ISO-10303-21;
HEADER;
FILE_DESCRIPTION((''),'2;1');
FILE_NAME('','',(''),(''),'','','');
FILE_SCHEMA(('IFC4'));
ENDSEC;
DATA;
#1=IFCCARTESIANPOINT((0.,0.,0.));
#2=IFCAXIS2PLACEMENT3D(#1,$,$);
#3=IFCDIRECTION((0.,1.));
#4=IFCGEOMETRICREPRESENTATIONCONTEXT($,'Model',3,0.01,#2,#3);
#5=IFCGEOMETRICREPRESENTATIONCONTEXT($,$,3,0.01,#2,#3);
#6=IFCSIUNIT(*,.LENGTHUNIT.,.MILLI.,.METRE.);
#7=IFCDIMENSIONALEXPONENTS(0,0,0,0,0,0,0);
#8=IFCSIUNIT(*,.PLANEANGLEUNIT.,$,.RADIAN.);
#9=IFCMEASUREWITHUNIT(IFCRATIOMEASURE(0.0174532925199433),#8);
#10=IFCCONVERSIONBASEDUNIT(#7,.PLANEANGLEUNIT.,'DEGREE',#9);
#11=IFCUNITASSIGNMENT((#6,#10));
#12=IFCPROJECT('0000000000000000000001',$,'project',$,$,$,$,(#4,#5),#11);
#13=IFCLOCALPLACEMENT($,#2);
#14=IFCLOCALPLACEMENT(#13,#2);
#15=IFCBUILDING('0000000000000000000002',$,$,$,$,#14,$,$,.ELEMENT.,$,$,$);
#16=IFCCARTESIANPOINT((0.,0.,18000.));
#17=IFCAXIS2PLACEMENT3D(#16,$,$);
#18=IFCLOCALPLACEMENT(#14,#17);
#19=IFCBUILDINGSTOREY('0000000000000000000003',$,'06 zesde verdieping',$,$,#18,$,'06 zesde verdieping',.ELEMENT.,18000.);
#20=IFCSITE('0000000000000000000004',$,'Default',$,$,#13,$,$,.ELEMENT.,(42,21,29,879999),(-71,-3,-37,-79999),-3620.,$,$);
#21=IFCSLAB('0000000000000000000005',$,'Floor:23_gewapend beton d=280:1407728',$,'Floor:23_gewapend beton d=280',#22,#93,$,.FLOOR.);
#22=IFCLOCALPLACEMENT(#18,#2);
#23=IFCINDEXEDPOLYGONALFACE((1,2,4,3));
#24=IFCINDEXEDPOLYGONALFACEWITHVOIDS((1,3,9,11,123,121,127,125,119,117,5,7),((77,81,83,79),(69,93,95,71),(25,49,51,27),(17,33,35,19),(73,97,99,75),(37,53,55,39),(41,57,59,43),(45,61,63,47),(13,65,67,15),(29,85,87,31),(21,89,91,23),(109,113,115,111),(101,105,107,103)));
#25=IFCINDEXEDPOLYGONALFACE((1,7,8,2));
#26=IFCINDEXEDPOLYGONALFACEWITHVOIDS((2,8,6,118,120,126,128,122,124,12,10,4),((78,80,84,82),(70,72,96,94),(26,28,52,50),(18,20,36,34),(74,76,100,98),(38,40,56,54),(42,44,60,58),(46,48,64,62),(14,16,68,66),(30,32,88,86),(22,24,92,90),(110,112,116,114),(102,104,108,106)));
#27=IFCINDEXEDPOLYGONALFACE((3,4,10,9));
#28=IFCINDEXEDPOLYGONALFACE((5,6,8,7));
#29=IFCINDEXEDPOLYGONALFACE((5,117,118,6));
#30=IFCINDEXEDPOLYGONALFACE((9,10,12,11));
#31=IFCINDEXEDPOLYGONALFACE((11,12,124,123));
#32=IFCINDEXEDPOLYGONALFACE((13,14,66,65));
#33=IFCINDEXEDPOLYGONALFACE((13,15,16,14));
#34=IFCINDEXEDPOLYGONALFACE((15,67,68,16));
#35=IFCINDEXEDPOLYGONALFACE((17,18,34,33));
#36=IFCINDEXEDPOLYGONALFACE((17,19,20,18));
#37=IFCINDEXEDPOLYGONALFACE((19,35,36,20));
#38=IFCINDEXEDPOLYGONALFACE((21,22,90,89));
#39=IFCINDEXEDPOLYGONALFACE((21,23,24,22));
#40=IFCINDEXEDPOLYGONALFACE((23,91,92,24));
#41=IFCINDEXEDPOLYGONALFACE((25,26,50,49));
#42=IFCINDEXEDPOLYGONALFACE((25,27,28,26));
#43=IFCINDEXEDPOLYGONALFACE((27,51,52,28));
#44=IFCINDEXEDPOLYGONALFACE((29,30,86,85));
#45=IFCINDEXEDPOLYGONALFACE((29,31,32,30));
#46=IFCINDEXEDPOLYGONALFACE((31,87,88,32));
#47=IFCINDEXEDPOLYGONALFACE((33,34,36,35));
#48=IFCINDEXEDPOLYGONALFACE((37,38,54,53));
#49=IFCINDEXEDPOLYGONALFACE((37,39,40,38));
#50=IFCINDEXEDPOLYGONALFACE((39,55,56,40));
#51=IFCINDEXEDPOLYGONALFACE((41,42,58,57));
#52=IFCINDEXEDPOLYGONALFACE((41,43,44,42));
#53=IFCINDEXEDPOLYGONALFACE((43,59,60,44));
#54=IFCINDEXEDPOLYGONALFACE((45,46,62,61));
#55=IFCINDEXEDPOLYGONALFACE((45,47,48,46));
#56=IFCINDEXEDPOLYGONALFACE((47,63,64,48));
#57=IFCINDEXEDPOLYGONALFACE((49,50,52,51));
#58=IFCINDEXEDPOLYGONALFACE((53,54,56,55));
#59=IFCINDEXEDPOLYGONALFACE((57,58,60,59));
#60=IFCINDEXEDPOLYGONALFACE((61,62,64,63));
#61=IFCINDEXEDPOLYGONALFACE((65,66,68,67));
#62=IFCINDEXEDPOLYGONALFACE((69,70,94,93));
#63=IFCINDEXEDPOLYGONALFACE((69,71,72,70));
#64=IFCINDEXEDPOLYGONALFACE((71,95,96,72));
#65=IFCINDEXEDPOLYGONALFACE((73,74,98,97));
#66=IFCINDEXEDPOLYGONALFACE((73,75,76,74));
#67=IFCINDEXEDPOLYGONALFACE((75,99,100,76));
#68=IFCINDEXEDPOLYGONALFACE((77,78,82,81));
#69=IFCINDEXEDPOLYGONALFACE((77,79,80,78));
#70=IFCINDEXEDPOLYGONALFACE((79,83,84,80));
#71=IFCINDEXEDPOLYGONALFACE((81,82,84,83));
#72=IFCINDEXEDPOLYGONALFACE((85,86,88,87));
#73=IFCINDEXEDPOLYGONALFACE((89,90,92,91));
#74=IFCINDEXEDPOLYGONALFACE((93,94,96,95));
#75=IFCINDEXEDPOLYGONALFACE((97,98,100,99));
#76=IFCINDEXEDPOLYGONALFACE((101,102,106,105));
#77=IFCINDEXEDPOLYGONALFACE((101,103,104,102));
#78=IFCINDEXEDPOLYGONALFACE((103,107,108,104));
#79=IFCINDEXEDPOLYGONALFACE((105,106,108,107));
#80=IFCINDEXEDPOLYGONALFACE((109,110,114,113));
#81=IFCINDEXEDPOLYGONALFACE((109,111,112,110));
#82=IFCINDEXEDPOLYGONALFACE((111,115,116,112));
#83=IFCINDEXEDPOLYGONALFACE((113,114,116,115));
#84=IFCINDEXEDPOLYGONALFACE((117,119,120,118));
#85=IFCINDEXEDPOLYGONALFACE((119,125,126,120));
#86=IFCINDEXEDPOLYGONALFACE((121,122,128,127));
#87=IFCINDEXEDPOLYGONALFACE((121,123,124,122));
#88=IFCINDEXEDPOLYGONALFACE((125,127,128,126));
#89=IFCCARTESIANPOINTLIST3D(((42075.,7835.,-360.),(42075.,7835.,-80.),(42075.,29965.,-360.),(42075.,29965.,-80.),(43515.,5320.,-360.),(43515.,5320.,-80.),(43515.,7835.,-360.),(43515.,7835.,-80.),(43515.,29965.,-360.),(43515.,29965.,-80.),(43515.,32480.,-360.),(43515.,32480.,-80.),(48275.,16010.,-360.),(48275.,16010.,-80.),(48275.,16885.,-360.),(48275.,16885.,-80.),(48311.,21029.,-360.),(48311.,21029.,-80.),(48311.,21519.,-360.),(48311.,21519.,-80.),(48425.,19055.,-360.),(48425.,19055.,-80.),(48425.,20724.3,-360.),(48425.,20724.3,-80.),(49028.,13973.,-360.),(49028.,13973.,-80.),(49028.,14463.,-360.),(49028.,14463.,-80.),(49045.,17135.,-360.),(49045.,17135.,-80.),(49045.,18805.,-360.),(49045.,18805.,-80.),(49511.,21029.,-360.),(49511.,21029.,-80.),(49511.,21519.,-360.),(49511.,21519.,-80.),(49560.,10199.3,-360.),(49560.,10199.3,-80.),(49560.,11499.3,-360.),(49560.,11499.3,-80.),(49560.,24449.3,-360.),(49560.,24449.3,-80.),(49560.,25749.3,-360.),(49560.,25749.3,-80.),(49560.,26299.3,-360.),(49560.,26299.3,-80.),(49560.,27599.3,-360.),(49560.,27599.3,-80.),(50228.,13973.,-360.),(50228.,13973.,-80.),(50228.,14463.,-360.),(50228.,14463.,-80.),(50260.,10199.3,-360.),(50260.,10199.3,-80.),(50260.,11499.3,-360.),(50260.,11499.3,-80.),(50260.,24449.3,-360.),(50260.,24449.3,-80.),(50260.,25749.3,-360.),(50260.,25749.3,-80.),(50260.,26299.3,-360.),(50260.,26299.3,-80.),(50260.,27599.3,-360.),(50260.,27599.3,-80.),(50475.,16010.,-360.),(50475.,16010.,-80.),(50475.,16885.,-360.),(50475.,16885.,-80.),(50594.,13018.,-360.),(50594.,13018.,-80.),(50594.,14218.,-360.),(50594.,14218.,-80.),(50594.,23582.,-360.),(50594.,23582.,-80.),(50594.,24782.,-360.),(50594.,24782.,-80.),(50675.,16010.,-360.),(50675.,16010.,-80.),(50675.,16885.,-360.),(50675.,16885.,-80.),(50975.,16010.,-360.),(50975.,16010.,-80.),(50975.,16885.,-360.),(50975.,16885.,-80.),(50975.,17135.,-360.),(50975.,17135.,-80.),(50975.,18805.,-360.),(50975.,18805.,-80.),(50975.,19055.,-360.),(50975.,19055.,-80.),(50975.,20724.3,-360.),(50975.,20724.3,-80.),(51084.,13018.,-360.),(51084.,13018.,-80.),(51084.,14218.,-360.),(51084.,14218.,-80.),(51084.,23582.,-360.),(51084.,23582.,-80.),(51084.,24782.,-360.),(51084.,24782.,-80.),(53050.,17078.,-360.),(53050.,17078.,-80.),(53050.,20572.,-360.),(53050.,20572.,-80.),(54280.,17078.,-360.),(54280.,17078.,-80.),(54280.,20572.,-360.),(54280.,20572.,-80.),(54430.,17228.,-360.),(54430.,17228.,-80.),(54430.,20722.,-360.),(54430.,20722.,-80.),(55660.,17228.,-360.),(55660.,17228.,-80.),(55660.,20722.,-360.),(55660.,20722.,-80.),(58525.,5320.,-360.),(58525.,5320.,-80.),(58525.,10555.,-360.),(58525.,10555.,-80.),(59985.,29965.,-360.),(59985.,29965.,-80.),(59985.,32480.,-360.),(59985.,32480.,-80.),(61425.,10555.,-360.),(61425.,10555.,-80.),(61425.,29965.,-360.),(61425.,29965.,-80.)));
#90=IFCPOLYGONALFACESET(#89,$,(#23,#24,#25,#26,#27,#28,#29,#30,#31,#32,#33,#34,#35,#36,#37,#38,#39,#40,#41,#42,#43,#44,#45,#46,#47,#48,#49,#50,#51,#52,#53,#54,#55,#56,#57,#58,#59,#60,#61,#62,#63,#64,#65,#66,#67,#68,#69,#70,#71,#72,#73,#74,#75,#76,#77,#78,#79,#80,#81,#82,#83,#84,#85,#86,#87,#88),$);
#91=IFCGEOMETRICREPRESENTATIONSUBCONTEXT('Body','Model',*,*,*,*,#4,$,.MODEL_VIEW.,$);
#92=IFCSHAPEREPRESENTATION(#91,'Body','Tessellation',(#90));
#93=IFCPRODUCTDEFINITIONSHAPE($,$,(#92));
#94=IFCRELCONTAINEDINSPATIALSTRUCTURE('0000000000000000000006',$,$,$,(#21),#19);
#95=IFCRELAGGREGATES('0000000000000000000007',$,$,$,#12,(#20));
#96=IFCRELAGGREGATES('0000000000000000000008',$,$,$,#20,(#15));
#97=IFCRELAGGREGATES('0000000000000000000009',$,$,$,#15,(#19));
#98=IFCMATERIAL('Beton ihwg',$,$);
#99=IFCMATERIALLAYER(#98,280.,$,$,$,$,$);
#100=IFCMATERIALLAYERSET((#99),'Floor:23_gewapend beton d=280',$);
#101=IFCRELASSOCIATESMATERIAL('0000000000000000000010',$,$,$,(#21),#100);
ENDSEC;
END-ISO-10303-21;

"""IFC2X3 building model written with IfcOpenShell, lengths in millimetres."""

from ifc_helpers import new_model, entity, si_unit, converted_unit, direction, frame, frame_2d, origin, place, context, subcontext, project, spatial, polyline, rectangle, outline, extrude, material, layer, layer_set, layer_usage, element, save


model = new_model("IFC2X3")

# Units and contexts
model_context = context("Model", 3, precision=0.01, world=origin(), true_north=direction((0.0, 1.0)))
context_of_model = context(None, 3, precision=0.01, world=origin(), true_north=direction((0.0, 1.0)))
body_context = subcontext(model_context, "Body", "Model", "MODEL_VIEW")
ifc_project = project(units=[si_unit("LENGTHUNIT", "METRE", prefix="MILLI"), converted_unit("PLANEANGLEUNIT", "DEGREE", entity("IfcRatioMeasure", 0.0174532925199433), si_unit("PLANEANGLEUNIT", "RADIAN"), dimensions=[0, 0, 0, 0, 0, 0, 0])], contexts=[model_context, context_of_model])

# Site, building, storey
site_placement = place(None, origin())
site = spatial("IfcSite", under=ifc_project, at=site_placement, Name="Default", CompositionType="ELEMENT", RefLatitude=(42, 21, 29, 879999), RefLongitude=(-71, -3, -37, -79999), RefElevation=-3620.0)
building_placement = place(site_placement, origin())
building = spatial("IfcBuilding", under=site, at=building_placement, CompositionType="ELEMENT")
storey_placement = place(building_placement, frame((0.0, 0.0, 18000.0)))
storey = spatial("IfcBuildingStorey", under=building, at=storey_placement, Name="06 zesde verdieping", LongName="06 zesde verdieping", CompositionType="ELEMENT", Elevation=18000.0)

# Slab, openings
ifc_material_1 = material(Name="Beton ihwg")
ifc_layer_1 = layer(ifc_material_1, 280.0)
ifc_layer_set_1 = layer_set([ifc_layer_1], Name="Floor:23_gewapend beton d=280")
ifc_layer_usage_1 = layer_usage(ifc_layer_set_1, "AXIS3", "POSITIVE", 0.0)
slab_1_placement = place(storey_placement, frame((42075.0, 5320.0, -360.0)))
slab_1 = element("IfcSlab", 1, at=slab_1_placement, inside=storey, material=ifc_layer_usage_1, Name="Floor:23_gewapend beton d=280:1407728", ObjectType="Floor:23_gewapend beton d=280", PredefinedType="FLOOR", context=body_context, shape_type="SweptSolid", body=[
    extrude(outline(polyline([(8235.0, 13580.0), (-8235.0, 13580.0), (-8235.0, 11065.0), (-9675.0, 11065.0), (-9675.0, -8345.0), (-6775.0, -8345.0), (-6775.0, -13580.0), (8235.0, -13580.0), (8235.0, -11065.0), (9675.0, -11065.0), (9675.0, 11065.0), (8235.0, 11065.0), (8235.0, 13580.0)])), frame((9675.0, 13580.0, 280.0), z_axis=(0.0, 0.0, -1.0), x_axis=(-1.0, 0.0, 0.0)), (0.0, 0.0, 1.0), 280.0),
])
opening_1_placement = place(storey_placement, frame((42075.0, 5320.0, -360.0)))
element("IfcOpeningElement", 2, at=opening_1_placement, cuts=slab_1, ObjectType="Opening", context=body_context, shape_type="SweptSolid", body=[
    extrude(rectangle(XDim=1669.3, YDim=2550.0, at=frame_2d((2050.0, 989.6), x_axis=(0.0, 1.0))), frame((9675.0, 13580.0, 280.0), z_axis=(0.0, 0.0, -1.0), x_axis=(-1.0, 0.0, 0.0)), (0.0, 0.0, 1.0), 280.0),
])
opening_2_placement = place(storey_placement, frame((42075.0, 5320.0, -360.0)))
element("IfcOpeningElement", 3, at=opening_2_placement, cuts=slab_1, ObjectType="Opening", context=body_context, shape_type="SweptSolid", body=[
    extrude(rectangle(XDim=1670.0, YDim=1930.0, at=frame_2d((1740.0, -930.0), x_axis=(0.0, 1.0))), frame((9675.0, 13580.0, 280.0), z_axis=(0.0, 0.0, -1.0), x_axis=(-1.0, 0.0, 0.0)), (0.0, 0.0, 1.0), 280.0),
])
opening_3_placement = place(storey_placement, frame((42075.0, 5320.0, -360.0)))
element("IfcOpeningElement", 4, at=opening_3_placement, cuts=slab_1, ObjectType="Opening", context=body_context, shape_type="SweptSolid", body=[
    extrude(rectangle(XDim=1300.0, YDim=700.0, at=frame_2d((1840.0, 8049.3), x_axis=(0.0, 1.0))), frame((9675.0, 13580.0, 280.0), z_axis=(0.0, 0.0, -1.0), x_axis=(-1.0, 0.0, 0.0)), (0.0, 0.0, 1.0), 280.0),
])
opening_4_placement = place(storey_placement, frame((42075.0, 5320.0, -360.0)))
element("IfcOpeningElement", 5, at=opening_4_placement, cuts=slab_1, ObjectType="Opening", context=body_context, shape_type="SweptSolid", body=[
    extrude(rectangle(XDim=1300.0, YDim=700.0, at=frame_2d((1840.0, 6199.3), x_axis=(0.0, 1.0))), frame((9675.0, 13580.0, 280.0), z_axis=(0.0, 0.0, -1.0), x_axis=(-1.0, 0.0, 0.0)), (0.0, 0.0, 1.0), 280.0),
])
opening_5_placement = place(storey_placement, frame((42075.0, 5320.0, -360.0)))
element("IfcOpeningElement", 6, at=opening_5_placement, cuts=slab_1, ObjectType="Opening", context=body_context, shape_type="SweptSolid", body=[
    extrude(rectangle(XDim=1300.0, YDim=700.0, at=frame_2d((1840.0, -8050.7), x_axis=(0.0, 1.0))), frame((9675.0, 13580.0, 280.0), z_axis=(0.0, 0.0, -1.0), x_axis=(-1.0, 0.0, 0.0)), (0.0, 0.0, 1.0), 280.0),
])
opening_6_placement = place(storey_placement, frame((42075.0, 5320.0, -360.0)))
element("IfcOpeningElement", 7, at=opening_6_placement, cuts=slab_1, ObjectType="Opening", context=body_context, shape_type="SweptSolid", body=[
    extrude(rectangle(XDim=875.0, YDim=2200.0, at=frame_2d((2375.0, -2452.5), x_axis=(0.0, 1.0))), frame((9675.0, 13580.0, 280.0), z_axis=(0.0, 0.0, -1.0), x_axis=(-1.0, 0.0, 0.0)), (0.0, 0.0, 1.0), 280.0),
])
opening_7_placement = place(storey_placement, frame((42075.0, 5320.0, -360.0)))
element("IfcOpeningElement", 8, at=opening_7_placement, cuts=slab_1, ObjectType="Opening", context=body_context, shape_type="SweptSolid", body=[
    extrude(rectangle(XDim=875.0, YDim=300.0, at=frame_2d((925.0, -2452.5), x_axis=(0.0, 1.0))), frame((9675.0, 13580.0, 280.0), z_axis=(0.0, 0.0, -1.0), x_axis=(-1.0, 0.0, 0.0)), (0.0, 0.0, 1.0), 280.0),
])
opening_8_placement = place(storey_placement, frame((42075.0, 5320.0, -360.0)))
element("IfcOpeningElement", 9, at=opening_8_placement, cuts=slab_1, ObjectType="Opening", context=body_context, shape_type="SweptSolid", body=[
    extrude(rectangle(XDim=3494.0, YDim=1230.0, at=frame_2d((-3295.0, 75.0), x_axis=(0.0, 1.0))), frame((9675.0, 13580.0, 280.0), z_axis=(0.0, 0.0, -1.0), x_axis=(-1.0, 0.0, 0.0)), (0.0, 0.0, 1.0), 280.0),
])
opening_9_placement = place(storey_placement, frame((42075.0, 5320.0, -360.0)))
element("IfcOpeningElement", 10, at=opening_9_placement, cuts=slab_1, ObjectType="Opening", context=body_context, shape_type="SweptSolid", body=[
    extrude(rectangle(XDim=3494.0, YDim=1230.0, at=frame_2d((-1915.0, -75.0), x_axis=(0.0, 1.0))), frame((9675.0, 13580.0, 280.0), z_axis=(0.0, 0.0, -1.0), x_axis=(-1.0, 0.0, 0.0)), (0.0, 0.0, 1.0), 280.0),
])
opening_10_placement = place(storey_placement, frame((42075.0, 5320.0, -360.0)))
element("IfcOpeningElement", 11, at=opening_10_placement, cuts=slab_1, ObjectType="Opening", context=body_context, shape_type="SweptSolid", body=[
    extrude(rectangle(XDim=490.0, YDim=1200.0, at=frame_2d((911.0, 5282.0), x_axis=(-1.0, 0.0))), frame((9675.0, 13580.0, 280.0), z_axis=(0.0, 0.0, -1.0), x_axis=(-1.0, 0.0, 0.0)), (0.0, 0.0, 1.0), 280.0),
])
opening_11_placement = place(storey_placement, frame((42075.0, 5320.0, -360.0)))
element("IfcOpeningElement", 12, at=opening_11_placement, cuts=slab_1, ObjectType="Opening", context=body_context, shape_type="SweptSolid", body=[
    extrude(rectangle(XDim=490.0, YDim=1200.0, at=frame_2d((2839.0, 2374.0), x_axis=(0.0, 1.0))), frame((9675.0, 13580.0, 280.0), z_axis=(0.0, 0.0, -1.0), x_axis=(-1.0, 0.0, 0.0)), (0.0, 0.0, 1.0), 280.0),
])
opening_12_placement = place(storey_placement, frame((42075.0, 5320.0, -360.0)))
element("IfcOpeningElement", 13, at=opening_12_placement, cuts=slab_1, ObjectType="Opening", context=body_context, shape_type="SweptSolid", body=[
    extrude(rectangle(XDim=490.0, YDim=1200.0, at=frame_2d((911.0, -5282.0), x_axis=(-1.0, 0.0))), frame((9675.0, 13580.0, 280.0), z_axis=(0.0, 0.0, -1.0), x_axis=(-1.0, 0.0, 0.0)), (0.0, 0.0, 1.0), 280.0),
])
opening_13_placement = place(storey_placement, frame((42075.0, 5320.0, -360.0)))
element("IfcOpeningElement", 14, at=opening_13_placement, cuts=slab_1, ObjectType="Opening", context=body_context, shape_type="SweptSolid", body=[
    extrude(rectangle(XDim=490.0, YDim=1200.0, at=frame_2d((2122.0, -4682.0), x_axis=(0.0, 1.0))), frame((9675.0, 13580.0, 280.0), z_axis=(0.0, 0.0, -1.0), x_axis=(-1.0, 0.0, 0.0)), (0.0, 0.0, 1.0), 280.0),
])

save(model, "model.ifc")
